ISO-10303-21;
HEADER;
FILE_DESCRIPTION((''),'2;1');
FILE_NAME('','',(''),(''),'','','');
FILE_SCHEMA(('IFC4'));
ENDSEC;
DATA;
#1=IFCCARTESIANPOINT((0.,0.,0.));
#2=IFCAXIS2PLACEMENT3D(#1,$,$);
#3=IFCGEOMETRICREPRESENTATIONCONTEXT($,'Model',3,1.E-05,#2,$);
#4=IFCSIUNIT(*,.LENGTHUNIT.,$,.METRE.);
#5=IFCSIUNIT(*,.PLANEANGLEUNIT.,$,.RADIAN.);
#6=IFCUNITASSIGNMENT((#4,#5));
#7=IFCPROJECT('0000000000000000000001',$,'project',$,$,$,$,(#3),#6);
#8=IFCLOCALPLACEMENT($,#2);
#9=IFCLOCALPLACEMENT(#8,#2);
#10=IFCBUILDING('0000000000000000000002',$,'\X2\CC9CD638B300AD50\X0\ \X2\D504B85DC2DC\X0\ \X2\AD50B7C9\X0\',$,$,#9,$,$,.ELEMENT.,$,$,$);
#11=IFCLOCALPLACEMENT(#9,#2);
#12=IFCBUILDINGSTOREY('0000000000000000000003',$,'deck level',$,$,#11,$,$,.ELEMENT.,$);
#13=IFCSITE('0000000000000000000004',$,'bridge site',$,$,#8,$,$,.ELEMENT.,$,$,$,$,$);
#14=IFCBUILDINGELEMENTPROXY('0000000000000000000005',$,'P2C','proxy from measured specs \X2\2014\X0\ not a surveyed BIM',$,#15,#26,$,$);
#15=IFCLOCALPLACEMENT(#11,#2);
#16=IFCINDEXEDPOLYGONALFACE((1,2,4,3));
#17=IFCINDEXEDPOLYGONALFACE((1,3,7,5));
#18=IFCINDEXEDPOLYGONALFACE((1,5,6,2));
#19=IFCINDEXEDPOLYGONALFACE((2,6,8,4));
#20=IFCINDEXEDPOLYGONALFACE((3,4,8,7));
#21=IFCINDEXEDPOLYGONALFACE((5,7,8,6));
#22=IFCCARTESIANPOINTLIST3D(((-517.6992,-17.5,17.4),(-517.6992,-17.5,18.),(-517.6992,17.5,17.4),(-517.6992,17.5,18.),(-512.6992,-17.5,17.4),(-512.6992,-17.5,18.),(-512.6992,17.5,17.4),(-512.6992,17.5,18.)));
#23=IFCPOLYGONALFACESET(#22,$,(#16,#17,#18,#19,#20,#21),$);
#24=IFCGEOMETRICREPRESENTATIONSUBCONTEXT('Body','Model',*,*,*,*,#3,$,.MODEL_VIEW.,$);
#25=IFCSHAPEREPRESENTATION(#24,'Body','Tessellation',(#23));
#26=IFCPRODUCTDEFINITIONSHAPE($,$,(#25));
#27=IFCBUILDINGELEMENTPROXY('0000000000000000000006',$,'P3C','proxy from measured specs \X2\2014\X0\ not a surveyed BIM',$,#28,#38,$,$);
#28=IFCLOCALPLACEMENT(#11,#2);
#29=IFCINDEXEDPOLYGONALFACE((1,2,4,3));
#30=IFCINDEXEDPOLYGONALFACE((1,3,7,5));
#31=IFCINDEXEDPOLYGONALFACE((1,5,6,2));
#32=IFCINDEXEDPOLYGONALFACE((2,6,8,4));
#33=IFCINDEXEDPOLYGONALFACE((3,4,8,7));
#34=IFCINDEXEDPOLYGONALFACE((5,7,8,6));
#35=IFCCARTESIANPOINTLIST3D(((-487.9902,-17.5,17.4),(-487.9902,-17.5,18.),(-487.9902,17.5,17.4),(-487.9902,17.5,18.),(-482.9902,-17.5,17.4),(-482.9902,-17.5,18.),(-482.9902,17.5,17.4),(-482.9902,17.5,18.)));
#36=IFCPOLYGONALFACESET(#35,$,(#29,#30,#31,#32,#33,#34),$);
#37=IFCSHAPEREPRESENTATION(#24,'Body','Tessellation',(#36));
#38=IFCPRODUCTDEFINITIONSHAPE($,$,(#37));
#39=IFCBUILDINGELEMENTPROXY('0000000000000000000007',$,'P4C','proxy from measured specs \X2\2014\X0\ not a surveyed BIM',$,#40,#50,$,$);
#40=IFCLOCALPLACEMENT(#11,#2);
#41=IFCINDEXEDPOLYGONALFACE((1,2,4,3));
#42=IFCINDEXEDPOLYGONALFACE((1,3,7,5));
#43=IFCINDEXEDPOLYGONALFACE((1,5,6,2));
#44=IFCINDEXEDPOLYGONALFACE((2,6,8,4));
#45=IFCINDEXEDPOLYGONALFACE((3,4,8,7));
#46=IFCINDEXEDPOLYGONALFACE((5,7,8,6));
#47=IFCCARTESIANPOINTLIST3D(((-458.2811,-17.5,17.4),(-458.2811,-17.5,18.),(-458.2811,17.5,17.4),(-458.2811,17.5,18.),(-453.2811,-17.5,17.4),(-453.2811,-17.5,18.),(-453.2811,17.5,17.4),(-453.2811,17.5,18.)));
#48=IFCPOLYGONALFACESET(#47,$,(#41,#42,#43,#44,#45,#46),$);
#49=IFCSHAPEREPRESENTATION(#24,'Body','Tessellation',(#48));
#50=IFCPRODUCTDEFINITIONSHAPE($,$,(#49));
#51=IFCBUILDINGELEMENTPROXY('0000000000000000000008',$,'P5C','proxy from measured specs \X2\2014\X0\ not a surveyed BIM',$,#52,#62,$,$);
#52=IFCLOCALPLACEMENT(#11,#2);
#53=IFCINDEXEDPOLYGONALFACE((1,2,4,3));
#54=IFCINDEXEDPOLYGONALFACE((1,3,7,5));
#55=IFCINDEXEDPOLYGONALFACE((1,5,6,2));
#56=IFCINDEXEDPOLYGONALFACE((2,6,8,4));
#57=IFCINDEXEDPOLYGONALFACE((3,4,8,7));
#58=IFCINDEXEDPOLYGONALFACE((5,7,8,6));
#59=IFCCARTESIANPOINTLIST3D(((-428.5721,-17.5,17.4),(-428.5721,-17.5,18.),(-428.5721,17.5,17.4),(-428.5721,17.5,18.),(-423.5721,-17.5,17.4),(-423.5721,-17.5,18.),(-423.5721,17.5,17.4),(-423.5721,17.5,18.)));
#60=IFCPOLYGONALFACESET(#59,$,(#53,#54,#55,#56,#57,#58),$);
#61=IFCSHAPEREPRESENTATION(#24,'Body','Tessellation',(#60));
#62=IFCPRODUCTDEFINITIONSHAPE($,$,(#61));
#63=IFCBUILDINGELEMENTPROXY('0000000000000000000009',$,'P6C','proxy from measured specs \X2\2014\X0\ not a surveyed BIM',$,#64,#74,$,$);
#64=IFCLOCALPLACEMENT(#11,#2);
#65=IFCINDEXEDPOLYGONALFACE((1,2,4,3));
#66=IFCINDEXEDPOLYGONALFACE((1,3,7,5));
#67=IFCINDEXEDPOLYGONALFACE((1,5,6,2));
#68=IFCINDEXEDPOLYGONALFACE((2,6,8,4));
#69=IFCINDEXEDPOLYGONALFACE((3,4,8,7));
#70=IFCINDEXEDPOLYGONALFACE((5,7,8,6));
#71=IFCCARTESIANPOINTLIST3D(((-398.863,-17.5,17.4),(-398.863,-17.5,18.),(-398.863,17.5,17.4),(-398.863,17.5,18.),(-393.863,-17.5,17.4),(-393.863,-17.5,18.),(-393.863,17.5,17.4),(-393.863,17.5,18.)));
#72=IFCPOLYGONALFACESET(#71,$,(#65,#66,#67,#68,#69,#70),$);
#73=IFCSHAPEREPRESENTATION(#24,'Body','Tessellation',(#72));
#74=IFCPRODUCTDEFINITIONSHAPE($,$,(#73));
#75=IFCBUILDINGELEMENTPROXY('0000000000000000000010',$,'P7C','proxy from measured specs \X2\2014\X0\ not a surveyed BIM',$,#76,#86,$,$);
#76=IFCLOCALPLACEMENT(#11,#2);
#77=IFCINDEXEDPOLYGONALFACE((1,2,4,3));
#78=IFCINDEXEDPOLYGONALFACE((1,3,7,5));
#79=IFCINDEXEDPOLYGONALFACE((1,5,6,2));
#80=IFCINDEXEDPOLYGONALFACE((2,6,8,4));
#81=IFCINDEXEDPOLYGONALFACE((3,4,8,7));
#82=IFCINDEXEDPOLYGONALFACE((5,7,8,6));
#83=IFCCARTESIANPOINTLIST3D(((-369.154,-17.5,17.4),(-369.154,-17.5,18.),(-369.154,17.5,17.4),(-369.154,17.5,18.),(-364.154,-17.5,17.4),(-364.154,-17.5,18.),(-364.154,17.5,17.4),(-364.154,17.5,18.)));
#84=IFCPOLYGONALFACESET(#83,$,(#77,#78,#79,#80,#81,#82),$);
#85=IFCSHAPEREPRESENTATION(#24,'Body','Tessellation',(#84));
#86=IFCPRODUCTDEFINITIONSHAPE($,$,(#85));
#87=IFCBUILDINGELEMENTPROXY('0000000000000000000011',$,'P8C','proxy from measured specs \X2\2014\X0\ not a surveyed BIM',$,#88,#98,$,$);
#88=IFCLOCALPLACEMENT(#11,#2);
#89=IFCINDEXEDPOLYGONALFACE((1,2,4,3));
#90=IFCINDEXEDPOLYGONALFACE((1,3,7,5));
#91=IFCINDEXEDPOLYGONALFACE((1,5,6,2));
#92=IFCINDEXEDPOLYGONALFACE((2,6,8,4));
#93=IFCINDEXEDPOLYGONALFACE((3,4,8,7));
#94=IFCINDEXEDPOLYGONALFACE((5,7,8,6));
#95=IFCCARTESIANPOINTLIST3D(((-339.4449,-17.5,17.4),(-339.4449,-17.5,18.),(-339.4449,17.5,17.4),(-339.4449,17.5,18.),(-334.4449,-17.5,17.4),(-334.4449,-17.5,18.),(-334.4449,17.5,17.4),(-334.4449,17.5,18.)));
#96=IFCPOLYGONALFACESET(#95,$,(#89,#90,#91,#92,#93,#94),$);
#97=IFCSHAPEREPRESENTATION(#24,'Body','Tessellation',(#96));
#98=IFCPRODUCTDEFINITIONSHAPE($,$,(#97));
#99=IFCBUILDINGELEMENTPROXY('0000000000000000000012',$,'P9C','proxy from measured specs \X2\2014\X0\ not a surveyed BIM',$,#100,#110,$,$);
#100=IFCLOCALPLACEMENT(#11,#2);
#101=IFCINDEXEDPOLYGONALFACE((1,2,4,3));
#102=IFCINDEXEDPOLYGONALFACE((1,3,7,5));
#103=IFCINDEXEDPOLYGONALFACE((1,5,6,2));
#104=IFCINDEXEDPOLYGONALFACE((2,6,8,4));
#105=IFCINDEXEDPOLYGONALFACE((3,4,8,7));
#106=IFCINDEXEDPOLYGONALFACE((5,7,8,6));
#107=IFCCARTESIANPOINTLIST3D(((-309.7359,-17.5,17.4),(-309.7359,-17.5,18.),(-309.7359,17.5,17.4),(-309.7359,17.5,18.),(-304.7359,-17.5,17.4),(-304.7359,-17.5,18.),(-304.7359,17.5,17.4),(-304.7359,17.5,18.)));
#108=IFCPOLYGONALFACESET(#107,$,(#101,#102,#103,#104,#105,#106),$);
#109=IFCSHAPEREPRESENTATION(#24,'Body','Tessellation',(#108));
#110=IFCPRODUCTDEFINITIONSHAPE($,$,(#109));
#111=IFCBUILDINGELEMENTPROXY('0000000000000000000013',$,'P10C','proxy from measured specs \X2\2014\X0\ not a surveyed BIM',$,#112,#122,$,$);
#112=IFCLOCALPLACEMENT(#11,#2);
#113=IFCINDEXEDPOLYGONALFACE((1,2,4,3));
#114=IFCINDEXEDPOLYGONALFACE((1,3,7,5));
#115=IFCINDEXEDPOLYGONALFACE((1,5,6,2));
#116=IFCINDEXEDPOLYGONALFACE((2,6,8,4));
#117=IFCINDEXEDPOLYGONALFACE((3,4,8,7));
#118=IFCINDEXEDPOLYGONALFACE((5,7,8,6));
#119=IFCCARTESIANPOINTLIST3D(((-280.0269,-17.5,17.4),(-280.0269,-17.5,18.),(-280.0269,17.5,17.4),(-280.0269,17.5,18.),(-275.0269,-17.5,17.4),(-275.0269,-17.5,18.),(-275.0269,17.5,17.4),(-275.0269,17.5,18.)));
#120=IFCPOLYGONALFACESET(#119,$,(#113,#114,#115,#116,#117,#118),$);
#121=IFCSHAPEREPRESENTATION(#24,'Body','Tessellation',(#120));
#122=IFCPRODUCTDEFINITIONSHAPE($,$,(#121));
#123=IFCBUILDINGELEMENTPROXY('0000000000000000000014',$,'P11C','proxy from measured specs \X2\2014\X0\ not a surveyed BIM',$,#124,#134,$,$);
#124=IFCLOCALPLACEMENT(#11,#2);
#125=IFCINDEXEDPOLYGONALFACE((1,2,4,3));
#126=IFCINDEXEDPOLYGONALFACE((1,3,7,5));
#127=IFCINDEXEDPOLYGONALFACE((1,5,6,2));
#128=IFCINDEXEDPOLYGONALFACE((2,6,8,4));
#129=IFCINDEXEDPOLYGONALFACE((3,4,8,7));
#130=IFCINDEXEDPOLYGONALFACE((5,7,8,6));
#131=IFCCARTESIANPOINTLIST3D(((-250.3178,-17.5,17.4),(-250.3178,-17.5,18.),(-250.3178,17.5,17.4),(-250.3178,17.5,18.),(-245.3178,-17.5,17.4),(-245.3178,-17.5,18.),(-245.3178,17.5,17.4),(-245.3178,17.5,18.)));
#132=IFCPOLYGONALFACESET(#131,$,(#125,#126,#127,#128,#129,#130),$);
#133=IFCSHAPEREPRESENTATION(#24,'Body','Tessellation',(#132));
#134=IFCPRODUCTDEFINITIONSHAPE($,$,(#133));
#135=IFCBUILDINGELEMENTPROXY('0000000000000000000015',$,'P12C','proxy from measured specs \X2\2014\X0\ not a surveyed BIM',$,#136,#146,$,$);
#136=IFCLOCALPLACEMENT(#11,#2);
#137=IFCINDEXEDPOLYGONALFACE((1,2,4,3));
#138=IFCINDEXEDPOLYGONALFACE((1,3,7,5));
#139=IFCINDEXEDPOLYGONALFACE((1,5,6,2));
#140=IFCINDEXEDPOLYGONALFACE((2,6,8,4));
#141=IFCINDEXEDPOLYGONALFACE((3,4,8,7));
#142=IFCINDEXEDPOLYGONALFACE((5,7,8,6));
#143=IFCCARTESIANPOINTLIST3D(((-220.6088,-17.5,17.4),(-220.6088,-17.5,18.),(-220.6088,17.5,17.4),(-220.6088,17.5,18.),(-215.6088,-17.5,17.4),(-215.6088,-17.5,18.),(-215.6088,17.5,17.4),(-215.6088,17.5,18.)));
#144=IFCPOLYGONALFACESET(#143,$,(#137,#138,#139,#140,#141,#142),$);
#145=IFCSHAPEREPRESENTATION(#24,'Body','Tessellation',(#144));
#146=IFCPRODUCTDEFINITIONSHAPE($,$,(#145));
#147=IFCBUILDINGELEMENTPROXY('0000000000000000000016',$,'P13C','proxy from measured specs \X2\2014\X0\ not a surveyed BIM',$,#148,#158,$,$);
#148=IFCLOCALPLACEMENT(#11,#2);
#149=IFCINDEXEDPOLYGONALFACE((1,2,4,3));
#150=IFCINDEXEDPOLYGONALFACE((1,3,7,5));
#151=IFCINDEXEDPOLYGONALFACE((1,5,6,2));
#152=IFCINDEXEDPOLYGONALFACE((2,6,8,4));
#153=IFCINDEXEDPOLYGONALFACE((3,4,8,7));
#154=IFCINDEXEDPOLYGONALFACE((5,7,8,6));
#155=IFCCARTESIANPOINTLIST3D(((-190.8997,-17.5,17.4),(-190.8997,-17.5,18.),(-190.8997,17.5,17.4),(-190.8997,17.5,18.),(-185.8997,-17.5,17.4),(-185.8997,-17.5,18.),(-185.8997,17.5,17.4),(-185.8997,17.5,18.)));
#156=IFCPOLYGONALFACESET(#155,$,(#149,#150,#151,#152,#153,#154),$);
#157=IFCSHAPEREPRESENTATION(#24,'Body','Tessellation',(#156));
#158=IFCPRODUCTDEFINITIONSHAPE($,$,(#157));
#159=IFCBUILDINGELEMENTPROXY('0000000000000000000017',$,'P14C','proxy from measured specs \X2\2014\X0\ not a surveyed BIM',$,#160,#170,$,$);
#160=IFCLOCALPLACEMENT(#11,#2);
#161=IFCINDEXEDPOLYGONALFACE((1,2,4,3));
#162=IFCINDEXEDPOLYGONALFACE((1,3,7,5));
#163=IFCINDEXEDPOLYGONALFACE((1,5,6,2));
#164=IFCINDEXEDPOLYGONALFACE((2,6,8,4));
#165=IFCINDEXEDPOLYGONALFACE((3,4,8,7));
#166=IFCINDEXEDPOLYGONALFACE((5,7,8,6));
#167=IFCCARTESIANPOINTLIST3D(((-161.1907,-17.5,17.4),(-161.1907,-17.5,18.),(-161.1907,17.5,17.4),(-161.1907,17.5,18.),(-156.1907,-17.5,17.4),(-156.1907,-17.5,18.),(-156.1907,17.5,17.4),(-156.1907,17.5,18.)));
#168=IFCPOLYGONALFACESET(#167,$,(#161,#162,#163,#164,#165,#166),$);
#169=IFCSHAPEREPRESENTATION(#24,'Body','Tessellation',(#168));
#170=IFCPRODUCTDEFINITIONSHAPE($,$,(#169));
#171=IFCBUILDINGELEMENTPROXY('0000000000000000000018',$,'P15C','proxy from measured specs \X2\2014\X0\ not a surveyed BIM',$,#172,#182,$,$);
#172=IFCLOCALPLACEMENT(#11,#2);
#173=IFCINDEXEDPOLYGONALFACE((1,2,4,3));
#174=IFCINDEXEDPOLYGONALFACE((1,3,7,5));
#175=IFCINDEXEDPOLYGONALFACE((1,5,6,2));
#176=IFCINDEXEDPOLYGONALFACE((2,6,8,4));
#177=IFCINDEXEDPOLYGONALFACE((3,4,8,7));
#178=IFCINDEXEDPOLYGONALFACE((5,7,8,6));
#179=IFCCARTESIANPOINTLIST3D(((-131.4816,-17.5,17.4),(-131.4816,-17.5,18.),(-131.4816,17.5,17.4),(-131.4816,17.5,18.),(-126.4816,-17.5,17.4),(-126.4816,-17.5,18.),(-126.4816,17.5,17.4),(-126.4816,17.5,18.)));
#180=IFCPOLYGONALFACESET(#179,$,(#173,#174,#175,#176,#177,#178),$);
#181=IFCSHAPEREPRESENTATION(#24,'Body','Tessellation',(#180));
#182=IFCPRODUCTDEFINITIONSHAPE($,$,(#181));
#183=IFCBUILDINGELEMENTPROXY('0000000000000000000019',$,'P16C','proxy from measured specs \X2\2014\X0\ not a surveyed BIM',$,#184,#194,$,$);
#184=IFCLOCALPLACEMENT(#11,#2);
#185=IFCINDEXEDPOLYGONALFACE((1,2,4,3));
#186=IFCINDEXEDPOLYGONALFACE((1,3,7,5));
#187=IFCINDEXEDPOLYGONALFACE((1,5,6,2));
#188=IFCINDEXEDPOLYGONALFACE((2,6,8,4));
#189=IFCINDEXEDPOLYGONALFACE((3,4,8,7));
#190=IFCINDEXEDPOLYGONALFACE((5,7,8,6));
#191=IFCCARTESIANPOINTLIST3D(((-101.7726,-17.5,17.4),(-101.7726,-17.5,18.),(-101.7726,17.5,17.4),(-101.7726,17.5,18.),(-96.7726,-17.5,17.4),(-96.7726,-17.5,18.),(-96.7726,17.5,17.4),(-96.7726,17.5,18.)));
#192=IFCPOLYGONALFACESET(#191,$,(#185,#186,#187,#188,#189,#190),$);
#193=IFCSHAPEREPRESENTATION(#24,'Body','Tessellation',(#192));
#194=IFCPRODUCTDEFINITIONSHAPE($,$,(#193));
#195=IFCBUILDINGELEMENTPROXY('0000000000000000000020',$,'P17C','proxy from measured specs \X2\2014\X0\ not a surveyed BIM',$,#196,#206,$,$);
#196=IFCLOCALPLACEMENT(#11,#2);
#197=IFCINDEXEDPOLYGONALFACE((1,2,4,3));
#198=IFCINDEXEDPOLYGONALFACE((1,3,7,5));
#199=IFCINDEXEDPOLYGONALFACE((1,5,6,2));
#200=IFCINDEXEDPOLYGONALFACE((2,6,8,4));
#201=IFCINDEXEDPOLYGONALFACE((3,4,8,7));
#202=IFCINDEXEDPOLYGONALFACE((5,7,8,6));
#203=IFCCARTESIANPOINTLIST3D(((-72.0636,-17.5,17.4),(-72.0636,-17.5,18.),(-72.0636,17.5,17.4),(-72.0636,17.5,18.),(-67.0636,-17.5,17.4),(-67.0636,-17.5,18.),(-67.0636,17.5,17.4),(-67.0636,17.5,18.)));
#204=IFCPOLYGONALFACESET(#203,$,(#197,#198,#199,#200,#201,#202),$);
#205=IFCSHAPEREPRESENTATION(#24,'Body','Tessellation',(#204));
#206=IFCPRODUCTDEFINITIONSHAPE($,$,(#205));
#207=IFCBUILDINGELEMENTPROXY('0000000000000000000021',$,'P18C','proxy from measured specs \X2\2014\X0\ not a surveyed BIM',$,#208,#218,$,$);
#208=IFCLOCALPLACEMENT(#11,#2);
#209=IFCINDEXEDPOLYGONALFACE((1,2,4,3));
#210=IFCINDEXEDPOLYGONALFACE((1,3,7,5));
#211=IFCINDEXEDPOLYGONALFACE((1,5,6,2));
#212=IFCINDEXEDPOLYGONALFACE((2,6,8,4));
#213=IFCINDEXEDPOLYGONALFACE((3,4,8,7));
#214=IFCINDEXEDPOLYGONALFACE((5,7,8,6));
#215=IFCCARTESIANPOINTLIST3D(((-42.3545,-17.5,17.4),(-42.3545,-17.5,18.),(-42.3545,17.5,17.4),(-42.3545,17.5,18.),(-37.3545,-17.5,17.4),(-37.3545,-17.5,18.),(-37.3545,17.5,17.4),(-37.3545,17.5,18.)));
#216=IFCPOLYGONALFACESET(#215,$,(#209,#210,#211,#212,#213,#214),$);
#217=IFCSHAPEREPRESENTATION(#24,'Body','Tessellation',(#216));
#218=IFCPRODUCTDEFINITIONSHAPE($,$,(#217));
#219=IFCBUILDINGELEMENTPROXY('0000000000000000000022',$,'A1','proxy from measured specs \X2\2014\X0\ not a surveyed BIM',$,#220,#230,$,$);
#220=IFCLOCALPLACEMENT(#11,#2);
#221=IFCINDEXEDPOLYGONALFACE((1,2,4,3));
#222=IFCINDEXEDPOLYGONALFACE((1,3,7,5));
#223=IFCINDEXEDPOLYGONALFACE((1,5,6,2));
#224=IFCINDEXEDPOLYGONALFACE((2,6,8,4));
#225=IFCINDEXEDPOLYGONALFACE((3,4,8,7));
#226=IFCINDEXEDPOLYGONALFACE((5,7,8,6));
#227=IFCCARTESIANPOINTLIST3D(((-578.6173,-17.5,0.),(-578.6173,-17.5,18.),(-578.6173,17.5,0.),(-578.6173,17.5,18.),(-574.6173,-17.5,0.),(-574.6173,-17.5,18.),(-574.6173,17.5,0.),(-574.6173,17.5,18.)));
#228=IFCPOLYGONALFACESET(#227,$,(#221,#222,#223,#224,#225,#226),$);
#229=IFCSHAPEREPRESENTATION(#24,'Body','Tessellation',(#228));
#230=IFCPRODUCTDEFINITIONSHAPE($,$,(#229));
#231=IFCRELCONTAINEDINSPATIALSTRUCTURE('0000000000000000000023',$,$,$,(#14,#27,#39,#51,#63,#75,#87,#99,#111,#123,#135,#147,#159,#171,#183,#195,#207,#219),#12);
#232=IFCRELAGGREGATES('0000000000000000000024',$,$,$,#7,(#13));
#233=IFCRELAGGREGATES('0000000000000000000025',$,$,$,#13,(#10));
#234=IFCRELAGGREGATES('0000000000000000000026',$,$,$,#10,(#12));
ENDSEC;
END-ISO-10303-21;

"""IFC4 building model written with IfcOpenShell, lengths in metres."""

from ifc_helpers import new_model, si_unit, frame, origin, origin_2d, place, context, subcontext, project, spatial, rectangle, extrude, element, save


model = new_model("IFC4")

# Units and contexts
model_context = context("Model", 3, precision=1e-05, world=origin())
body_context = subcontext(model_context, "Body", "Model", "MODEL_VIEW")
ifc_project = project(units=[si_unit("LENGTHUNIT", "METRE"), si_unit("PLANEANGLEUNIT", "RADIAN")], contexts=[model_context])

# Site, building, storey
site_placement = place(None, origin())
site = spatial("IfcSite", under=ifc_project, at=site_placement, Name="bridge site", CompositionType="ELEMENT")
building_placement = place(site_placement, origin())
building = spatial("IfcBuilding", under=site, at=building_placement, Name="천호대교 프록시 교량", CompositionType="ELEMENT")
storey_placement = place(building_placement, origin())
storey = spatial("IfcBuildingStorey", under=building, at=storey_placement, Name="deck level", CompositionType="ELEMENT")

# Building element proxies
for number, where, name in (
    (1, (-515.1992, 0.0, 17.4), "P2C"),
    (2, (-485.4902, 0.0, 17.4), "P3C"),
    (3, (-455.7811, 0.0, 17.4), "P4C"),
    (4, (-426.0721, 0.0, 17.4), "P5C"),
    (5, (-396.363, 0.0, 17.4), "P6C"),
    (6, (-366.654, 0.0, 17.4), "P7C"),
    (7, (-336.9449, 0.0, 17.4), "P8C"),
    (8, (-307.2359, 0.0, 17.4), "P9C"),
    (9, (-277.5269, 0.0, 17.4), "P10C"),
    (10, (-247.8178, 0.0, 17.4), "P11C"),
    (11, (-218.1088, 0.0, 17.4), "P12C"),
    (12, (-188.3997, 0.0, 17.4), "P13C"),
    (13, (-158.6907, 0.0, 17.4), "P14C"),
    (14, (-128.9816, 0.0, 17.4), "P15C"),
    (15, (-99.2726, 0.0, 17.4), "P16C"),
    (16, (-69.5636, 0.0, 17.4), "P17C"),
    (17, (-39.8545, 0.0, 17.4), "P18C"),
):
    element("IfcBuildingElementProxy", number, at=place(storey_placement, frame(where)), inside=storey, Name=name, Description="proxy from measured specs — not a surveyed BIM", context=body_context, shape_type="SweptSolid", body=[
        extrude(rectangle(XDim=5.0, YDim=35.0, at=origin_2d()), origin(), (0.0, 0.0, 1.0), 0.6),
    ])
proxy_placement = place(storey_placement, frame((-576.6173, 0.0, 0.0)))
element("IfcBuildingElementProxy", 18, at=proxy_placement, inside=storey, Name="A1", Description="proxy from measured specs — not a surveyed BIM", context=body_context, shape_type="SweptSolid", body=[
    extrude(rectangle(XDim=4.0, YDim=35.0, at=origin_2d()), origin(), (0.0, 0.0, 1.0), 18.0),
])

save(model, "model.ifc")
